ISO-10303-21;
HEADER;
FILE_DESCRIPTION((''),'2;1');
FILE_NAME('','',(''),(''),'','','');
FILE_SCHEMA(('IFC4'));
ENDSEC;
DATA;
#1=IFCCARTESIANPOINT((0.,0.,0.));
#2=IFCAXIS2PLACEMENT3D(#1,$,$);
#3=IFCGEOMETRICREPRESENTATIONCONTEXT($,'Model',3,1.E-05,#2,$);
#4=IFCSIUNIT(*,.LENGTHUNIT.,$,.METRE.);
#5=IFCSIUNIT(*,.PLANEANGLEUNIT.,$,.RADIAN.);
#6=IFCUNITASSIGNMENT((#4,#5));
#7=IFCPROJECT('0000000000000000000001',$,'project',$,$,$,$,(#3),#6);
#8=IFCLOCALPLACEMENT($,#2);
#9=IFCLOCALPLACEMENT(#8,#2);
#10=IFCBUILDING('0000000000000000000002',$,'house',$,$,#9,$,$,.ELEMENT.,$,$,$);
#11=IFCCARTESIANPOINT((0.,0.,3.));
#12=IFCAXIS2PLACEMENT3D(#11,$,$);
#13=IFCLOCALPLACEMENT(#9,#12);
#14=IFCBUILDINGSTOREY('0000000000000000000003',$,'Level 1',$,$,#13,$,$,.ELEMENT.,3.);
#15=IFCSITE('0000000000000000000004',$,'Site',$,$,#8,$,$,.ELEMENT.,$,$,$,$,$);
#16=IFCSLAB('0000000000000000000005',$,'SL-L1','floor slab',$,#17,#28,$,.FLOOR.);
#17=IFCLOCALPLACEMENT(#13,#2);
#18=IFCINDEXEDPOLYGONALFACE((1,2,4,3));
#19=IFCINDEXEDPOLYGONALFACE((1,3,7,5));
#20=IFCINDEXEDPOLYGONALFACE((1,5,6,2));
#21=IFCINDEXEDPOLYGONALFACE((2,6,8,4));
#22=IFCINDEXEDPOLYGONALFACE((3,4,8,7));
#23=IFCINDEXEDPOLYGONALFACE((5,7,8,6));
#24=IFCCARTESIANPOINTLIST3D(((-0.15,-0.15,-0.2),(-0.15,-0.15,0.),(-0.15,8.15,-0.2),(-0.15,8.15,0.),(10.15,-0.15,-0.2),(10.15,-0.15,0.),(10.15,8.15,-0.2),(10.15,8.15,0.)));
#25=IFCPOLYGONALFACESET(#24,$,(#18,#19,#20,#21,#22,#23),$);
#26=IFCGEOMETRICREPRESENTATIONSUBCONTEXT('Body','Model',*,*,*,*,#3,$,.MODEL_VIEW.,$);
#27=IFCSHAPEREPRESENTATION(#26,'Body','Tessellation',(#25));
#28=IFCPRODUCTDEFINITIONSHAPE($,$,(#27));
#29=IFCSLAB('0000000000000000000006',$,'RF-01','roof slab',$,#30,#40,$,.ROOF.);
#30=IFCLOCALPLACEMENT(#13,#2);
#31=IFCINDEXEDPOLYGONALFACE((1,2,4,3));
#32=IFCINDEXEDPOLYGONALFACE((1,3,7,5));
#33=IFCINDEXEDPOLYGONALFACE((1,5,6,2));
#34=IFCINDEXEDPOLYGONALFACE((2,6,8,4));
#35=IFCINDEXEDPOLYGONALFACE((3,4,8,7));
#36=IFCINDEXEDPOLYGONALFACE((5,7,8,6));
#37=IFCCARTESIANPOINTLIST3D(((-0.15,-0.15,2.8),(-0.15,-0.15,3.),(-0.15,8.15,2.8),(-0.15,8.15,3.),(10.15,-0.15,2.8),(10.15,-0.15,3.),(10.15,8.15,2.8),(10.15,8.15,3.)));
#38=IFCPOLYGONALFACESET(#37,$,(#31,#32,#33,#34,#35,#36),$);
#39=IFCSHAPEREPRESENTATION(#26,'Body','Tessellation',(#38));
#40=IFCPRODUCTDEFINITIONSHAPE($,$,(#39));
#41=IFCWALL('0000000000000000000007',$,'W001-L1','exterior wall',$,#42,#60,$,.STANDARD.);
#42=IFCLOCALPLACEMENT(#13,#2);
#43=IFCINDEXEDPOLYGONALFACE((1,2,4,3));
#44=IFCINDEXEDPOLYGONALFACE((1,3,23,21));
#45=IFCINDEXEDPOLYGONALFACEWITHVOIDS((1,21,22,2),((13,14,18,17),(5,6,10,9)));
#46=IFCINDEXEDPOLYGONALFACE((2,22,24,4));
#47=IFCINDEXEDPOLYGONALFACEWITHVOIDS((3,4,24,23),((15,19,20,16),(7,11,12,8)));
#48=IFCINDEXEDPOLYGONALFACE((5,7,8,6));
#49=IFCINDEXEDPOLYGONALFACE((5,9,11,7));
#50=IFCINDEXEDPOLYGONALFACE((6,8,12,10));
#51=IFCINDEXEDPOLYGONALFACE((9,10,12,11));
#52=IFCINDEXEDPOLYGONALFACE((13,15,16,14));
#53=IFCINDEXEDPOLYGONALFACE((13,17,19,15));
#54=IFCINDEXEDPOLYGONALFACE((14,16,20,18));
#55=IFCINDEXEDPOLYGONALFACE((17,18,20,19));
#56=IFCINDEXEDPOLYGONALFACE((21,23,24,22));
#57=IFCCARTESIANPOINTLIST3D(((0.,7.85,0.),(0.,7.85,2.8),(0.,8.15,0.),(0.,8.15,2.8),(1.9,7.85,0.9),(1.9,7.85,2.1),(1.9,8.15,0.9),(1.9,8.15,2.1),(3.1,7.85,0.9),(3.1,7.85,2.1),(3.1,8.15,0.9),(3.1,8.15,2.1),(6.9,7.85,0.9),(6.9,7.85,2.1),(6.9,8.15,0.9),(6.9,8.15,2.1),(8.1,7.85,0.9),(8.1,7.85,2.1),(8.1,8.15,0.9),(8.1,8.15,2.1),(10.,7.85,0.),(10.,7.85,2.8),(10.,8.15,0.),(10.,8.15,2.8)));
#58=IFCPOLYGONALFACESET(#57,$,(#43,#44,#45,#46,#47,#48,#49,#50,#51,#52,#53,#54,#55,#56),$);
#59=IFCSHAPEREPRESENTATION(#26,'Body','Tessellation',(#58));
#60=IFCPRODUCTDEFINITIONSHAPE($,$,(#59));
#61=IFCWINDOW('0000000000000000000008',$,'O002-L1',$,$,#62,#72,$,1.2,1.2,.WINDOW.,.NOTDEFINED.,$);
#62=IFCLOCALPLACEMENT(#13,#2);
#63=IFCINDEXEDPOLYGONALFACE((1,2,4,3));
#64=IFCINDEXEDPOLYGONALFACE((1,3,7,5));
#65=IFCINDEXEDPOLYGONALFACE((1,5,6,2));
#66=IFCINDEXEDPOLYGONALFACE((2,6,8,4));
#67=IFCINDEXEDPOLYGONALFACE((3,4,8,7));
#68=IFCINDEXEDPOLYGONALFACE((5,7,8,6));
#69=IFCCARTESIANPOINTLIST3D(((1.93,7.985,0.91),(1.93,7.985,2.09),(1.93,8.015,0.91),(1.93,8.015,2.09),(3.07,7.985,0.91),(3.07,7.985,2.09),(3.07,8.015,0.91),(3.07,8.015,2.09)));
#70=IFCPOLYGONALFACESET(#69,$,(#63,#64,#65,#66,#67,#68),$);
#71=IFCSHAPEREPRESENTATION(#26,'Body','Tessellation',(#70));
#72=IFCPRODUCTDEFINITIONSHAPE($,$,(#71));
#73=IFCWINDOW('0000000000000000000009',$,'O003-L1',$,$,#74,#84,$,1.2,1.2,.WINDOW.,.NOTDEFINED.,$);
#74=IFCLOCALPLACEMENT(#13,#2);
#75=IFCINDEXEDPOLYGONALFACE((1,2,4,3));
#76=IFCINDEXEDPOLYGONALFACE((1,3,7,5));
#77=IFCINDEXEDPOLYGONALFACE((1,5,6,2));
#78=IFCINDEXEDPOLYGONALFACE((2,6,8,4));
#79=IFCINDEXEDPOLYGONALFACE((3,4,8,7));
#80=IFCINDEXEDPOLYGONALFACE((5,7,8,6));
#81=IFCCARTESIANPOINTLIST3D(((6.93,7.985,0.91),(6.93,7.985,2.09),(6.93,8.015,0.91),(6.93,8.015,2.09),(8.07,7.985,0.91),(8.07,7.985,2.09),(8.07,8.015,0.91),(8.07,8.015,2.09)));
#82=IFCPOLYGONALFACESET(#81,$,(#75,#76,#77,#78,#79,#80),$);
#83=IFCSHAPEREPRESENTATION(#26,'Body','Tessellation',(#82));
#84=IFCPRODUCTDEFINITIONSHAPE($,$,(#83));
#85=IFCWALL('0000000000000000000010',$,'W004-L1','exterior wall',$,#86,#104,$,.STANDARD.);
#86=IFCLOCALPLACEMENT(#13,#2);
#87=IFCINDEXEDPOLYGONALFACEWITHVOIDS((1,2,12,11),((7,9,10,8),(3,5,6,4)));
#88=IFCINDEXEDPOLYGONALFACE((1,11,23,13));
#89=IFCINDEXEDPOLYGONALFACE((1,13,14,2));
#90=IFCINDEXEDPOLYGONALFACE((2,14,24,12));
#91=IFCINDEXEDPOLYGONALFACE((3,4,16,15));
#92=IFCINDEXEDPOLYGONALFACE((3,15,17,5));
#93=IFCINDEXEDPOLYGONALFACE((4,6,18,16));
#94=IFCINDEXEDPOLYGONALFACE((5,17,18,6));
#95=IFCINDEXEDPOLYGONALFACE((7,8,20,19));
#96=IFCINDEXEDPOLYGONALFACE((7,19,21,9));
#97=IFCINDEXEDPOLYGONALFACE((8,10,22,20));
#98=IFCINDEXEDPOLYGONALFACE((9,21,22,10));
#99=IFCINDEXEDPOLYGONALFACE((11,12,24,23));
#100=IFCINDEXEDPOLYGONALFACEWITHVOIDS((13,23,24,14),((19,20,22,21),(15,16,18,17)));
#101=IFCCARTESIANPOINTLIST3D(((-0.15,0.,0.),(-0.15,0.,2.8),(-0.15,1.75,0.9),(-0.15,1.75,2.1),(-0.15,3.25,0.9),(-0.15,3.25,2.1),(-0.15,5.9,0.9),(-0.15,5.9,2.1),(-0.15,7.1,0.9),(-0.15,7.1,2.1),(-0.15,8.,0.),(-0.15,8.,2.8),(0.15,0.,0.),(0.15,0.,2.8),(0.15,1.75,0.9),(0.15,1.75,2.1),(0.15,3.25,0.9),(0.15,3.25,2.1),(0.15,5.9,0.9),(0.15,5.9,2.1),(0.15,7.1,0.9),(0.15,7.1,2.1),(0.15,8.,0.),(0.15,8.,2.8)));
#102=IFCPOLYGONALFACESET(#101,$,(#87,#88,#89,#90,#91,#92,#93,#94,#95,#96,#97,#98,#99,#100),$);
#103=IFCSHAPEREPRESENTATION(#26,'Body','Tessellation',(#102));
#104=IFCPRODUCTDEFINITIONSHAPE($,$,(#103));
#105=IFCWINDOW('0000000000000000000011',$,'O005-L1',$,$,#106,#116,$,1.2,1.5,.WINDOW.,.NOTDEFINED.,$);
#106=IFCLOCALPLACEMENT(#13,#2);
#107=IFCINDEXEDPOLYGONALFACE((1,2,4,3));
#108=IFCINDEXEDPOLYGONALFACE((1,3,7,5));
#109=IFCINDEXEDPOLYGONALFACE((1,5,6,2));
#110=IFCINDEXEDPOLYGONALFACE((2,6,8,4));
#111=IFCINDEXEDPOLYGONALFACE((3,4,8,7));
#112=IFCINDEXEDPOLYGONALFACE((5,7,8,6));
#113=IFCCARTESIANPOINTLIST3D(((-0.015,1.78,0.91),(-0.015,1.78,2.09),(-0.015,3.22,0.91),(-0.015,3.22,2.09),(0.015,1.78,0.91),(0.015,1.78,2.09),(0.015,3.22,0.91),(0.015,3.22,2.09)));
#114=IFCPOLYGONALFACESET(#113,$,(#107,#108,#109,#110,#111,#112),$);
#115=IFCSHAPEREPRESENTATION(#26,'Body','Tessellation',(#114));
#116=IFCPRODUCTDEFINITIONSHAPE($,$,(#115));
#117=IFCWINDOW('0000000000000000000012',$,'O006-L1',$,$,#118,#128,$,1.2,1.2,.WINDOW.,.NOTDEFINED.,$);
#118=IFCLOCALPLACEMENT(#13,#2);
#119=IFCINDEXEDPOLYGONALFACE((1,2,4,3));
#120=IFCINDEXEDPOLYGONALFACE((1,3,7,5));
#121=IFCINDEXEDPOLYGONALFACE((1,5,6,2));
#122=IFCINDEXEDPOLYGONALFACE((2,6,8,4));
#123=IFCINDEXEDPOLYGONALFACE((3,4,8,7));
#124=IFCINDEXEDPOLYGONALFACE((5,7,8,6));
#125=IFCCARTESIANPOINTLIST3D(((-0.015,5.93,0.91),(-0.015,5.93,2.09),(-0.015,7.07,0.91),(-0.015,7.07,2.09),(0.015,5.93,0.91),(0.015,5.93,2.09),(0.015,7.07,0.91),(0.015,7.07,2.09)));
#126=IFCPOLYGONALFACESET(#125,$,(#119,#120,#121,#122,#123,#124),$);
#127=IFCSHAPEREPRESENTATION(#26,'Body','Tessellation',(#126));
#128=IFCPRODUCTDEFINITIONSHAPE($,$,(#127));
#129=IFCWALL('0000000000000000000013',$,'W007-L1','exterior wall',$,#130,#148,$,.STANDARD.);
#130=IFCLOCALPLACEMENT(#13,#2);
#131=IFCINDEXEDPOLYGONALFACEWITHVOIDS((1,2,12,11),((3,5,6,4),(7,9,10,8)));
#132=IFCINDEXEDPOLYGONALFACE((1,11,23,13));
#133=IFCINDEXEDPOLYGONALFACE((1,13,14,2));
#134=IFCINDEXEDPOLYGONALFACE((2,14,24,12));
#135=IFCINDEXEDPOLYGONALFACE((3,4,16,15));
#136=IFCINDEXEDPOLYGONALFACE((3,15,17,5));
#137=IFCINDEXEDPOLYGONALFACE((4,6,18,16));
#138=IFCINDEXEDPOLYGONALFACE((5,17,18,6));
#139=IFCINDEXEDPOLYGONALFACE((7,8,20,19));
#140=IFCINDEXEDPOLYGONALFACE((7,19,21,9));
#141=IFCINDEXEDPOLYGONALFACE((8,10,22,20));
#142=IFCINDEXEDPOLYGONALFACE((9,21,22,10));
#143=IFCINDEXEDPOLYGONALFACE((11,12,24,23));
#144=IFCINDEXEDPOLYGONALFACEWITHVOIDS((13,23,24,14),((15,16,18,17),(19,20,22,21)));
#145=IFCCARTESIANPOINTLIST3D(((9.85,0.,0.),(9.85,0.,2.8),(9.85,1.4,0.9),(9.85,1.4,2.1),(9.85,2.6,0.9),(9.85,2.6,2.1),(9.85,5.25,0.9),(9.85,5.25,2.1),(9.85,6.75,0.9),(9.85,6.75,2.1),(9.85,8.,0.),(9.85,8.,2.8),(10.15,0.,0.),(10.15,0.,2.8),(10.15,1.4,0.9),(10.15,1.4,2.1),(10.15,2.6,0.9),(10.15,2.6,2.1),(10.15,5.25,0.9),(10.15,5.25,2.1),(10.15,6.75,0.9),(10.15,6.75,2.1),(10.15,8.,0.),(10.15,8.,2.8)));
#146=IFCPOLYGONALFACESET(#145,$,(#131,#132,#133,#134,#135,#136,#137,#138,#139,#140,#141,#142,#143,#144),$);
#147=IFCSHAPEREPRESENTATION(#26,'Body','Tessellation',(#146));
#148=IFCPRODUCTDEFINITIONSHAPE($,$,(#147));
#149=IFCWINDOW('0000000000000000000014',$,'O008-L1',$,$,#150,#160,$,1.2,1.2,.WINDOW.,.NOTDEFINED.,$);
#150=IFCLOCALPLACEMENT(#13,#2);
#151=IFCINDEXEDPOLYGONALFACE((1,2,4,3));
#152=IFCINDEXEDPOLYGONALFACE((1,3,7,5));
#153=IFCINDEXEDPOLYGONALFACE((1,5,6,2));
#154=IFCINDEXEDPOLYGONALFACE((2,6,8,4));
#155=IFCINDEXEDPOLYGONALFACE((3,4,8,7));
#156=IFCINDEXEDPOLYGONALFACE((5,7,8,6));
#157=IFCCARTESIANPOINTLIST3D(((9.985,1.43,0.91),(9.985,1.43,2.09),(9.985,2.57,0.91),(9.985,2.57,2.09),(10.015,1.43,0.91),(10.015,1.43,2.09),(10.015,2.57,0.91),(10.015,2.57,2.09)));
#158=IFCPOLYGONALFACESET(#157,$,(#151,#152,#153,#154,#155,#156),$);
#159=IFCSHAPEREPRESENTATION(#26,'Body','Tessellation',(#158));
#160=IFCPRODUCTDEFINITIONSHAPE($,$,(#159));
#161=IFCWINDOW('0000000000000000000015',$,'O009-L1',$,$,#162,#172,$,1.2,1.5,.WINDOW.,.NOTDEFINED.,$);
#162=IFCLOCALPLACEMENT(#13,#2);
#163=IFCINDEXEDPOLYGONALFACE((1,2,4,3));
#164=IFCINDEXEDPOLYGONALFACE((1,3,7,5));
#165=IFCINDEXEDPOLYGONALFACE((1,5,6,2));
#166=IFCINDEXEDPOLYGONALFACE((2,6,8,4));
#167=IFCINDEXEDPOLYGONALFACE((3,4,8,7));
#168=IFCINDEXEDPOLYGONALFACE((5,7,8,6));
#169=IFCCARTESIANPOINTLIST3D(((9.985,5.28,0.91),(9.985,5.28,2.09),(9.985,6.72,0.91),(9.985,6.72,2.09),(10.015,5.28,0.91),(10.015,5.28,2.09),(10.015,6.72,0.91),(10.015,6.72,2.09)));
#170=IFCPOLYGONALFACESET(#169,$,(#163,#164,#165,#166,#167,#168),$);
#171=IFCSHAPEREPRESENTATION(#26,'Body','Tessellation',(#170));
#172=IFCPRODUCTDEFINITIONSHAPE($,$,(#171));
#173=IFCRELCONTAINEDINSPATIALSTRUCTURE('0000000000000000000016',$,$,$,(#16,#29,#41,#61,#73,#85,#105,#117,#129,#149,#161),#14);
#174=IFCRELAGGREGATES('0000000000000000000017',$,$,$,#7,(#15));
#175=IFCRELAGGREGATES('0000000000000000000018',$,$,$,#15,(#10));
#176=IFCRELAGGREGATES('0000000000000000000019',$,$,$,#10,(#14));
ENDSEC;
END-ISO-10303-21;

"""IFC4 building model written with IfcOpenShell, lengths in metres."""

from ifc_helpers import new_model, si_unit, frame, origin, origin_2d, place, context, subcontext, project, spatial, polyline, rectangle, outline, extrude, element, fill, save


model = new_model("IFC4")

# Units and contexts
model_context = context("Model", 3, precision=1e-05, world=origin())
body_context = subcontext(model_context, "Body", "Model", "MODEL_VIEW")
ifc_project = project(units=[si_unit("LENGTHUNIT", "METRE"), si_unit("PLANEANGLEUNIT", "RADIAN")], contexts=[model_context])

# Site, building, storey
site_placement = place(None, origin())
site = spatial("IfcSite", under=ifc_project, at=site_placement, Name="Site", CompositionType="ELEMENT")
building_placement = place(site_placement, origin())
building = spatial("IfcBuilding", under=site, at=building_placement, Name="house", CompositionType="ELEMENT")
storey_placement = place(building_placement, frame((0.0, 0.0, 3.0)))
storey = spatial("IfcBuildingStorey", under=building, at=storey_placement, Name="Level 1", CompositionType="ELEMENT", Elevation=3.0)

# Slabs
slab_1_placement = place(storey_placement, frame((0.0, 0.0, -0.2)))
element("IfcSlab", 1, at=slab_1_placement, inside=storey, Name="SL-L1", Description="floor slab", PredefinedType="FLOOR", context=body_context, shape_type="SweptSolid", body=[
    extrude(outline(polyline([(-0.15, 8.15), (10.15, 8.15), (10.15, -0.15), (-0.15, -0.15), (-0.15, 8.15)])), origin(), (0.0, 0.0, 1.0), 0.2),
])
slab_2_placement = place(storey_placement, frame((0.0, 0.0, 2.8)))
element("IfcSlab", 2, at=slab_2_placement, inside=storey, Name="RF-01", Description="roof slab", PredefinedType="ROOF", context=body_context, shape_type="SweptSolid", body=[
    extrude(outline(polyline([(-0.15, 8.15), (10.15, 8.15), (10.15, -0.15), (-0.15, -0.15), (-0.15, 8.15)])), origin(), (0.0, 0.0, 1.0), 0.2),
])

# Walls, openings, windows
wall_1_placement = place(storey_placement, frame((5.0, 8.0, 0.0), z_axis=(0.0, 0.0, 1.0), x_axis=(1.0, 0.0, 0.0)))
wall_1 = element("IfcWall", 3, at=wall_1_placement, inside=storey, Name="W001-L1", Description="exterior wall", PredefinedType="STANDARD", context=body_context, shape_type="SweptSolid", body=[
    extrude(rectangle(XDim=10.0, YDim=0.3, at=origin_2d()), origin(), (0.0, 0.0, 1.0), 2.8),
])
opening_1_placement = place(wall_1_placement, frame((-2.5, 0.0, 0.9)))
opening_1 = element("IfcOpeningElement", 4, at=opening_1_placement, cuts=wall_1, PredefinedType="OPENING", context=body_context, shape_type="SweptSolid", body=[
    extrude(rectangle(XDim=1.2, YDim=0.36, at=origin_2d()), origin(), (0.0, 0.0, 1.0), 1.2),
])
opening_2_placement = place(wall_1_placement, frame((2.5, 0.0, 0.9)))
opening_2 = element("IfcOpeningElement", 5, at=opening_2_placement, cuts=wall_1, PredefinedType="OPENING", context=body_context, shape_type="SweptSolid", body=[
    extrude(rectangle(XDim=1.2, YDim=0.36, at=origin_2d()), origin(), (0.0, 0.0, 1.0), 1.2),
])
window_1_placement = place(wall_1_placement, frame((-2.5, 0.0, 0.9)))
window_1 = element("IfcWindow", 6, at=window_1_placement, inside=storey, Name="O002-L1", OverallHeight=1.2, OverallWidth=1.2, PartitioningType="NOTDEFINED", PredefinedType="WINDOW", context=body_context, shape_type="SweptSolid", body=[
    extrude(rectangle(XDim=1.14, YDim=0.03, at=origin_2d()), frame((0.0, 0.0, 0.01)), (0.0, 0.0, 1.0), 1.18),
])
fill(opening_1, window_1)
window_2_placement = place(wall_1_placement, frame((2.5, 0.0, 0.9)))
window_2 = element("IfcWindow", 7, at=window_2_placement, inside=storey, Name="O003-L1", OverallHeight=1.2, OverallWidth=1.2, PartitioningType="NOTDEFINED", PredefinedType="WINDOW", context=body_context, shape_type="SweptSolid", body=[
    extrude(rectangle(XDim=1.14, YDim=0.03, at=origin_2d()), frame((0.0, 0.0, 0.01)), (0.0, 0.0, 1.0), 1.18),
])
fill(opening_2, window_2)
wall_2_placement = place(storey_placement, frame((0.0, 4.0, 0.0), z_axis=(0.0, 0.0, 1.0), x_axis=(0.0, 1.0, 0.0)))
wall_2 = element("IfcWall", 8, at=wall_2_placement, inside=storey, Name="W004-L1", Description="exterior wall", PredefinedType="STANDARD", context=body_context, shape_type="SweptSolid", body=[
    extrude(rectangle(XDim=8.0, YDim=0.3, at=origin_2d()), origin(), (0.0, 0.0, 1.0), 2.8),
])
opening_3_placement = place(wall_2_placement, frame((-1.5, 0.0, 0.9)))
opening_3 = element("IfcOpeningElement", 9, at=opening_3_placement, cuts=wall_2, PredefinedType="OPENING", context=body_context, shape_type="SweptSolid", body=[
    extrude(rectangle(XDim=1.5, YDim=0.36, at=origin_2d()), origin(), (0.0, 0.0, 1.0), 1.2),
])
opening_4_placement = place(wall_2_placement, frame((2.5, 0.0, 0.9)))
opening_4 = element("IfcOpeningElement", 10, at=opening_4_placement, cuts=wall_2, PredefinedType="OPENING", context=body_context, shape_type="SweptSolid", body=[
    extrude(rectangle(XDim=1.2, YDim=0.36, at=origin_2d()), origin(), (0.0, 0.0, 1.0), 1.2),
])
window_3_placement = place(wall_2_placement, frame((-1.5, 0.0, 0.9)))
window_3 = element("IfcWindow", 11, at=window_3_placement, inside=storey, Name="O005-L1", OverallHeight=1.2, OverallWidth=1.5, PartitioningType="NOTDEFINED", PredefinedType="WINDOW", context=body_context, shape_type="SweptSolid", body=[
    extrude(rectangle(XDim=1.44, YDim=0.03, at=origin_2d()), frame((0.0, 0.0, 0.01)), (0.0, 0.0, 1.0), 1.18),
])
fill(opening_3, window_3)
window_4_placement = place(wall_2_placement, frame((2.5, 0.0, 0.9)))
window_4 = element("IfcWindow", 12, at=window_4_placement, inside=storey, Name="O006-L1", OverallHeight=1.2, OverallWidth=1.2, PartitioningType="NOTDEFINED", PredefinedType="WINDOW", context=body_context, shape_type="SweptSolid", body=[
    extrude(rectangle(XDim=1.14, YDim=0.03, at=origin_2d()), frame((0.0, 0.0, 0.01)), (0.0, 0.0, 1.0), 1.18),
])
fill(opening_4, window_4)
wall_3_placement = place(storey_placement, frame((10.0, 4.0, 0.0), z_axis=(0.0, 0.0, 1.0), x_axis=(0.0, 1.0, 0.0)))
wall_3 = element("IfcWall", 13, at=wall_3_placement, inside=storey, Name="W007-L1", Description="exterior wall", PredefinedType="STANDARD", context=body_context, shape_type="SweptSolid", body=[
    extrude(rectangle(XDim=8.0, YDim=0.3, at=origin_2d()), origin(), (0.0, 0.0, 1.0), 2.8),
])
opening_5_placement = place(wall_3_placement, frame((-2.0, 0.0, 0.9)))
opening_5 = element("IfcOpeningElement", 14, at=opening_5_placement, cuts=wall_3, PredefinedType="OPENING", context=body_context, shape_type="SweptSolid", body=[
    extrude(rectangle(XDim=1.2, YDim=0.36, at=origin_2d()), origin(), (0.0, 0.0, 1.0), 1.2),
])
opening_6_placement = place(wall_3_placement, frame((2.0, 0.0, 0.9)))
opening_6 = element("IfcOpeningElement", 15, at=opening_6_placement, cuts=wall_3, PredefinedType="OPENING", context=body_context, shape_type="SweptSolid", body=[
    extrude(rectangle(XDim=1.5, YDim=0.36, at=origin_2d()), origin(), (0.0, 0.0, 1.0), 1.2),
])
window_5_placement = place(wall_3_placement, frame((-2.0, 0.0, 0.9)))
window_5 = element("IfcWindow", 16, at=window_5_placement, inside=storey, Name="O008-L1", OverallHeight=1.2, OverallWidth=1.2, PartitioningType="NOTDEFINED", PredefinedType="WINDOW", context=body_context, shape_type="SweptSolid", body=[
    extrude(rectangle(XDim=1.14, YDim=0.03, at=origin_2d()), frame((0.0, 0.0, 0.01)), (0.0, 0.0, 1.0), 1.18),
])
fill(opening_5, window_5)
window_6_placement = place(wall_3_placement, frame((2.0, 0.0, 0.9)))
window_6 = element("IfcWindow", 17, at=window_6_placement, inside=storey, Name="O009-L1", OverallHeight=1.2, OverallWidth=1.5, PartitioningType="NOTDEFINED", PredefinedType="WINDOW", context=body_context, shape_type="SweptSolid", body=[
    extrude(rectangle(XDim=1.44, YDim=0.03, at=origin_2d()), frame((0.0, 0.0, 0.01)), (0.0, 0.0, 1.0), 1.18),
])
fill(opening_6, window_6)

save(model, "model.ifc")
